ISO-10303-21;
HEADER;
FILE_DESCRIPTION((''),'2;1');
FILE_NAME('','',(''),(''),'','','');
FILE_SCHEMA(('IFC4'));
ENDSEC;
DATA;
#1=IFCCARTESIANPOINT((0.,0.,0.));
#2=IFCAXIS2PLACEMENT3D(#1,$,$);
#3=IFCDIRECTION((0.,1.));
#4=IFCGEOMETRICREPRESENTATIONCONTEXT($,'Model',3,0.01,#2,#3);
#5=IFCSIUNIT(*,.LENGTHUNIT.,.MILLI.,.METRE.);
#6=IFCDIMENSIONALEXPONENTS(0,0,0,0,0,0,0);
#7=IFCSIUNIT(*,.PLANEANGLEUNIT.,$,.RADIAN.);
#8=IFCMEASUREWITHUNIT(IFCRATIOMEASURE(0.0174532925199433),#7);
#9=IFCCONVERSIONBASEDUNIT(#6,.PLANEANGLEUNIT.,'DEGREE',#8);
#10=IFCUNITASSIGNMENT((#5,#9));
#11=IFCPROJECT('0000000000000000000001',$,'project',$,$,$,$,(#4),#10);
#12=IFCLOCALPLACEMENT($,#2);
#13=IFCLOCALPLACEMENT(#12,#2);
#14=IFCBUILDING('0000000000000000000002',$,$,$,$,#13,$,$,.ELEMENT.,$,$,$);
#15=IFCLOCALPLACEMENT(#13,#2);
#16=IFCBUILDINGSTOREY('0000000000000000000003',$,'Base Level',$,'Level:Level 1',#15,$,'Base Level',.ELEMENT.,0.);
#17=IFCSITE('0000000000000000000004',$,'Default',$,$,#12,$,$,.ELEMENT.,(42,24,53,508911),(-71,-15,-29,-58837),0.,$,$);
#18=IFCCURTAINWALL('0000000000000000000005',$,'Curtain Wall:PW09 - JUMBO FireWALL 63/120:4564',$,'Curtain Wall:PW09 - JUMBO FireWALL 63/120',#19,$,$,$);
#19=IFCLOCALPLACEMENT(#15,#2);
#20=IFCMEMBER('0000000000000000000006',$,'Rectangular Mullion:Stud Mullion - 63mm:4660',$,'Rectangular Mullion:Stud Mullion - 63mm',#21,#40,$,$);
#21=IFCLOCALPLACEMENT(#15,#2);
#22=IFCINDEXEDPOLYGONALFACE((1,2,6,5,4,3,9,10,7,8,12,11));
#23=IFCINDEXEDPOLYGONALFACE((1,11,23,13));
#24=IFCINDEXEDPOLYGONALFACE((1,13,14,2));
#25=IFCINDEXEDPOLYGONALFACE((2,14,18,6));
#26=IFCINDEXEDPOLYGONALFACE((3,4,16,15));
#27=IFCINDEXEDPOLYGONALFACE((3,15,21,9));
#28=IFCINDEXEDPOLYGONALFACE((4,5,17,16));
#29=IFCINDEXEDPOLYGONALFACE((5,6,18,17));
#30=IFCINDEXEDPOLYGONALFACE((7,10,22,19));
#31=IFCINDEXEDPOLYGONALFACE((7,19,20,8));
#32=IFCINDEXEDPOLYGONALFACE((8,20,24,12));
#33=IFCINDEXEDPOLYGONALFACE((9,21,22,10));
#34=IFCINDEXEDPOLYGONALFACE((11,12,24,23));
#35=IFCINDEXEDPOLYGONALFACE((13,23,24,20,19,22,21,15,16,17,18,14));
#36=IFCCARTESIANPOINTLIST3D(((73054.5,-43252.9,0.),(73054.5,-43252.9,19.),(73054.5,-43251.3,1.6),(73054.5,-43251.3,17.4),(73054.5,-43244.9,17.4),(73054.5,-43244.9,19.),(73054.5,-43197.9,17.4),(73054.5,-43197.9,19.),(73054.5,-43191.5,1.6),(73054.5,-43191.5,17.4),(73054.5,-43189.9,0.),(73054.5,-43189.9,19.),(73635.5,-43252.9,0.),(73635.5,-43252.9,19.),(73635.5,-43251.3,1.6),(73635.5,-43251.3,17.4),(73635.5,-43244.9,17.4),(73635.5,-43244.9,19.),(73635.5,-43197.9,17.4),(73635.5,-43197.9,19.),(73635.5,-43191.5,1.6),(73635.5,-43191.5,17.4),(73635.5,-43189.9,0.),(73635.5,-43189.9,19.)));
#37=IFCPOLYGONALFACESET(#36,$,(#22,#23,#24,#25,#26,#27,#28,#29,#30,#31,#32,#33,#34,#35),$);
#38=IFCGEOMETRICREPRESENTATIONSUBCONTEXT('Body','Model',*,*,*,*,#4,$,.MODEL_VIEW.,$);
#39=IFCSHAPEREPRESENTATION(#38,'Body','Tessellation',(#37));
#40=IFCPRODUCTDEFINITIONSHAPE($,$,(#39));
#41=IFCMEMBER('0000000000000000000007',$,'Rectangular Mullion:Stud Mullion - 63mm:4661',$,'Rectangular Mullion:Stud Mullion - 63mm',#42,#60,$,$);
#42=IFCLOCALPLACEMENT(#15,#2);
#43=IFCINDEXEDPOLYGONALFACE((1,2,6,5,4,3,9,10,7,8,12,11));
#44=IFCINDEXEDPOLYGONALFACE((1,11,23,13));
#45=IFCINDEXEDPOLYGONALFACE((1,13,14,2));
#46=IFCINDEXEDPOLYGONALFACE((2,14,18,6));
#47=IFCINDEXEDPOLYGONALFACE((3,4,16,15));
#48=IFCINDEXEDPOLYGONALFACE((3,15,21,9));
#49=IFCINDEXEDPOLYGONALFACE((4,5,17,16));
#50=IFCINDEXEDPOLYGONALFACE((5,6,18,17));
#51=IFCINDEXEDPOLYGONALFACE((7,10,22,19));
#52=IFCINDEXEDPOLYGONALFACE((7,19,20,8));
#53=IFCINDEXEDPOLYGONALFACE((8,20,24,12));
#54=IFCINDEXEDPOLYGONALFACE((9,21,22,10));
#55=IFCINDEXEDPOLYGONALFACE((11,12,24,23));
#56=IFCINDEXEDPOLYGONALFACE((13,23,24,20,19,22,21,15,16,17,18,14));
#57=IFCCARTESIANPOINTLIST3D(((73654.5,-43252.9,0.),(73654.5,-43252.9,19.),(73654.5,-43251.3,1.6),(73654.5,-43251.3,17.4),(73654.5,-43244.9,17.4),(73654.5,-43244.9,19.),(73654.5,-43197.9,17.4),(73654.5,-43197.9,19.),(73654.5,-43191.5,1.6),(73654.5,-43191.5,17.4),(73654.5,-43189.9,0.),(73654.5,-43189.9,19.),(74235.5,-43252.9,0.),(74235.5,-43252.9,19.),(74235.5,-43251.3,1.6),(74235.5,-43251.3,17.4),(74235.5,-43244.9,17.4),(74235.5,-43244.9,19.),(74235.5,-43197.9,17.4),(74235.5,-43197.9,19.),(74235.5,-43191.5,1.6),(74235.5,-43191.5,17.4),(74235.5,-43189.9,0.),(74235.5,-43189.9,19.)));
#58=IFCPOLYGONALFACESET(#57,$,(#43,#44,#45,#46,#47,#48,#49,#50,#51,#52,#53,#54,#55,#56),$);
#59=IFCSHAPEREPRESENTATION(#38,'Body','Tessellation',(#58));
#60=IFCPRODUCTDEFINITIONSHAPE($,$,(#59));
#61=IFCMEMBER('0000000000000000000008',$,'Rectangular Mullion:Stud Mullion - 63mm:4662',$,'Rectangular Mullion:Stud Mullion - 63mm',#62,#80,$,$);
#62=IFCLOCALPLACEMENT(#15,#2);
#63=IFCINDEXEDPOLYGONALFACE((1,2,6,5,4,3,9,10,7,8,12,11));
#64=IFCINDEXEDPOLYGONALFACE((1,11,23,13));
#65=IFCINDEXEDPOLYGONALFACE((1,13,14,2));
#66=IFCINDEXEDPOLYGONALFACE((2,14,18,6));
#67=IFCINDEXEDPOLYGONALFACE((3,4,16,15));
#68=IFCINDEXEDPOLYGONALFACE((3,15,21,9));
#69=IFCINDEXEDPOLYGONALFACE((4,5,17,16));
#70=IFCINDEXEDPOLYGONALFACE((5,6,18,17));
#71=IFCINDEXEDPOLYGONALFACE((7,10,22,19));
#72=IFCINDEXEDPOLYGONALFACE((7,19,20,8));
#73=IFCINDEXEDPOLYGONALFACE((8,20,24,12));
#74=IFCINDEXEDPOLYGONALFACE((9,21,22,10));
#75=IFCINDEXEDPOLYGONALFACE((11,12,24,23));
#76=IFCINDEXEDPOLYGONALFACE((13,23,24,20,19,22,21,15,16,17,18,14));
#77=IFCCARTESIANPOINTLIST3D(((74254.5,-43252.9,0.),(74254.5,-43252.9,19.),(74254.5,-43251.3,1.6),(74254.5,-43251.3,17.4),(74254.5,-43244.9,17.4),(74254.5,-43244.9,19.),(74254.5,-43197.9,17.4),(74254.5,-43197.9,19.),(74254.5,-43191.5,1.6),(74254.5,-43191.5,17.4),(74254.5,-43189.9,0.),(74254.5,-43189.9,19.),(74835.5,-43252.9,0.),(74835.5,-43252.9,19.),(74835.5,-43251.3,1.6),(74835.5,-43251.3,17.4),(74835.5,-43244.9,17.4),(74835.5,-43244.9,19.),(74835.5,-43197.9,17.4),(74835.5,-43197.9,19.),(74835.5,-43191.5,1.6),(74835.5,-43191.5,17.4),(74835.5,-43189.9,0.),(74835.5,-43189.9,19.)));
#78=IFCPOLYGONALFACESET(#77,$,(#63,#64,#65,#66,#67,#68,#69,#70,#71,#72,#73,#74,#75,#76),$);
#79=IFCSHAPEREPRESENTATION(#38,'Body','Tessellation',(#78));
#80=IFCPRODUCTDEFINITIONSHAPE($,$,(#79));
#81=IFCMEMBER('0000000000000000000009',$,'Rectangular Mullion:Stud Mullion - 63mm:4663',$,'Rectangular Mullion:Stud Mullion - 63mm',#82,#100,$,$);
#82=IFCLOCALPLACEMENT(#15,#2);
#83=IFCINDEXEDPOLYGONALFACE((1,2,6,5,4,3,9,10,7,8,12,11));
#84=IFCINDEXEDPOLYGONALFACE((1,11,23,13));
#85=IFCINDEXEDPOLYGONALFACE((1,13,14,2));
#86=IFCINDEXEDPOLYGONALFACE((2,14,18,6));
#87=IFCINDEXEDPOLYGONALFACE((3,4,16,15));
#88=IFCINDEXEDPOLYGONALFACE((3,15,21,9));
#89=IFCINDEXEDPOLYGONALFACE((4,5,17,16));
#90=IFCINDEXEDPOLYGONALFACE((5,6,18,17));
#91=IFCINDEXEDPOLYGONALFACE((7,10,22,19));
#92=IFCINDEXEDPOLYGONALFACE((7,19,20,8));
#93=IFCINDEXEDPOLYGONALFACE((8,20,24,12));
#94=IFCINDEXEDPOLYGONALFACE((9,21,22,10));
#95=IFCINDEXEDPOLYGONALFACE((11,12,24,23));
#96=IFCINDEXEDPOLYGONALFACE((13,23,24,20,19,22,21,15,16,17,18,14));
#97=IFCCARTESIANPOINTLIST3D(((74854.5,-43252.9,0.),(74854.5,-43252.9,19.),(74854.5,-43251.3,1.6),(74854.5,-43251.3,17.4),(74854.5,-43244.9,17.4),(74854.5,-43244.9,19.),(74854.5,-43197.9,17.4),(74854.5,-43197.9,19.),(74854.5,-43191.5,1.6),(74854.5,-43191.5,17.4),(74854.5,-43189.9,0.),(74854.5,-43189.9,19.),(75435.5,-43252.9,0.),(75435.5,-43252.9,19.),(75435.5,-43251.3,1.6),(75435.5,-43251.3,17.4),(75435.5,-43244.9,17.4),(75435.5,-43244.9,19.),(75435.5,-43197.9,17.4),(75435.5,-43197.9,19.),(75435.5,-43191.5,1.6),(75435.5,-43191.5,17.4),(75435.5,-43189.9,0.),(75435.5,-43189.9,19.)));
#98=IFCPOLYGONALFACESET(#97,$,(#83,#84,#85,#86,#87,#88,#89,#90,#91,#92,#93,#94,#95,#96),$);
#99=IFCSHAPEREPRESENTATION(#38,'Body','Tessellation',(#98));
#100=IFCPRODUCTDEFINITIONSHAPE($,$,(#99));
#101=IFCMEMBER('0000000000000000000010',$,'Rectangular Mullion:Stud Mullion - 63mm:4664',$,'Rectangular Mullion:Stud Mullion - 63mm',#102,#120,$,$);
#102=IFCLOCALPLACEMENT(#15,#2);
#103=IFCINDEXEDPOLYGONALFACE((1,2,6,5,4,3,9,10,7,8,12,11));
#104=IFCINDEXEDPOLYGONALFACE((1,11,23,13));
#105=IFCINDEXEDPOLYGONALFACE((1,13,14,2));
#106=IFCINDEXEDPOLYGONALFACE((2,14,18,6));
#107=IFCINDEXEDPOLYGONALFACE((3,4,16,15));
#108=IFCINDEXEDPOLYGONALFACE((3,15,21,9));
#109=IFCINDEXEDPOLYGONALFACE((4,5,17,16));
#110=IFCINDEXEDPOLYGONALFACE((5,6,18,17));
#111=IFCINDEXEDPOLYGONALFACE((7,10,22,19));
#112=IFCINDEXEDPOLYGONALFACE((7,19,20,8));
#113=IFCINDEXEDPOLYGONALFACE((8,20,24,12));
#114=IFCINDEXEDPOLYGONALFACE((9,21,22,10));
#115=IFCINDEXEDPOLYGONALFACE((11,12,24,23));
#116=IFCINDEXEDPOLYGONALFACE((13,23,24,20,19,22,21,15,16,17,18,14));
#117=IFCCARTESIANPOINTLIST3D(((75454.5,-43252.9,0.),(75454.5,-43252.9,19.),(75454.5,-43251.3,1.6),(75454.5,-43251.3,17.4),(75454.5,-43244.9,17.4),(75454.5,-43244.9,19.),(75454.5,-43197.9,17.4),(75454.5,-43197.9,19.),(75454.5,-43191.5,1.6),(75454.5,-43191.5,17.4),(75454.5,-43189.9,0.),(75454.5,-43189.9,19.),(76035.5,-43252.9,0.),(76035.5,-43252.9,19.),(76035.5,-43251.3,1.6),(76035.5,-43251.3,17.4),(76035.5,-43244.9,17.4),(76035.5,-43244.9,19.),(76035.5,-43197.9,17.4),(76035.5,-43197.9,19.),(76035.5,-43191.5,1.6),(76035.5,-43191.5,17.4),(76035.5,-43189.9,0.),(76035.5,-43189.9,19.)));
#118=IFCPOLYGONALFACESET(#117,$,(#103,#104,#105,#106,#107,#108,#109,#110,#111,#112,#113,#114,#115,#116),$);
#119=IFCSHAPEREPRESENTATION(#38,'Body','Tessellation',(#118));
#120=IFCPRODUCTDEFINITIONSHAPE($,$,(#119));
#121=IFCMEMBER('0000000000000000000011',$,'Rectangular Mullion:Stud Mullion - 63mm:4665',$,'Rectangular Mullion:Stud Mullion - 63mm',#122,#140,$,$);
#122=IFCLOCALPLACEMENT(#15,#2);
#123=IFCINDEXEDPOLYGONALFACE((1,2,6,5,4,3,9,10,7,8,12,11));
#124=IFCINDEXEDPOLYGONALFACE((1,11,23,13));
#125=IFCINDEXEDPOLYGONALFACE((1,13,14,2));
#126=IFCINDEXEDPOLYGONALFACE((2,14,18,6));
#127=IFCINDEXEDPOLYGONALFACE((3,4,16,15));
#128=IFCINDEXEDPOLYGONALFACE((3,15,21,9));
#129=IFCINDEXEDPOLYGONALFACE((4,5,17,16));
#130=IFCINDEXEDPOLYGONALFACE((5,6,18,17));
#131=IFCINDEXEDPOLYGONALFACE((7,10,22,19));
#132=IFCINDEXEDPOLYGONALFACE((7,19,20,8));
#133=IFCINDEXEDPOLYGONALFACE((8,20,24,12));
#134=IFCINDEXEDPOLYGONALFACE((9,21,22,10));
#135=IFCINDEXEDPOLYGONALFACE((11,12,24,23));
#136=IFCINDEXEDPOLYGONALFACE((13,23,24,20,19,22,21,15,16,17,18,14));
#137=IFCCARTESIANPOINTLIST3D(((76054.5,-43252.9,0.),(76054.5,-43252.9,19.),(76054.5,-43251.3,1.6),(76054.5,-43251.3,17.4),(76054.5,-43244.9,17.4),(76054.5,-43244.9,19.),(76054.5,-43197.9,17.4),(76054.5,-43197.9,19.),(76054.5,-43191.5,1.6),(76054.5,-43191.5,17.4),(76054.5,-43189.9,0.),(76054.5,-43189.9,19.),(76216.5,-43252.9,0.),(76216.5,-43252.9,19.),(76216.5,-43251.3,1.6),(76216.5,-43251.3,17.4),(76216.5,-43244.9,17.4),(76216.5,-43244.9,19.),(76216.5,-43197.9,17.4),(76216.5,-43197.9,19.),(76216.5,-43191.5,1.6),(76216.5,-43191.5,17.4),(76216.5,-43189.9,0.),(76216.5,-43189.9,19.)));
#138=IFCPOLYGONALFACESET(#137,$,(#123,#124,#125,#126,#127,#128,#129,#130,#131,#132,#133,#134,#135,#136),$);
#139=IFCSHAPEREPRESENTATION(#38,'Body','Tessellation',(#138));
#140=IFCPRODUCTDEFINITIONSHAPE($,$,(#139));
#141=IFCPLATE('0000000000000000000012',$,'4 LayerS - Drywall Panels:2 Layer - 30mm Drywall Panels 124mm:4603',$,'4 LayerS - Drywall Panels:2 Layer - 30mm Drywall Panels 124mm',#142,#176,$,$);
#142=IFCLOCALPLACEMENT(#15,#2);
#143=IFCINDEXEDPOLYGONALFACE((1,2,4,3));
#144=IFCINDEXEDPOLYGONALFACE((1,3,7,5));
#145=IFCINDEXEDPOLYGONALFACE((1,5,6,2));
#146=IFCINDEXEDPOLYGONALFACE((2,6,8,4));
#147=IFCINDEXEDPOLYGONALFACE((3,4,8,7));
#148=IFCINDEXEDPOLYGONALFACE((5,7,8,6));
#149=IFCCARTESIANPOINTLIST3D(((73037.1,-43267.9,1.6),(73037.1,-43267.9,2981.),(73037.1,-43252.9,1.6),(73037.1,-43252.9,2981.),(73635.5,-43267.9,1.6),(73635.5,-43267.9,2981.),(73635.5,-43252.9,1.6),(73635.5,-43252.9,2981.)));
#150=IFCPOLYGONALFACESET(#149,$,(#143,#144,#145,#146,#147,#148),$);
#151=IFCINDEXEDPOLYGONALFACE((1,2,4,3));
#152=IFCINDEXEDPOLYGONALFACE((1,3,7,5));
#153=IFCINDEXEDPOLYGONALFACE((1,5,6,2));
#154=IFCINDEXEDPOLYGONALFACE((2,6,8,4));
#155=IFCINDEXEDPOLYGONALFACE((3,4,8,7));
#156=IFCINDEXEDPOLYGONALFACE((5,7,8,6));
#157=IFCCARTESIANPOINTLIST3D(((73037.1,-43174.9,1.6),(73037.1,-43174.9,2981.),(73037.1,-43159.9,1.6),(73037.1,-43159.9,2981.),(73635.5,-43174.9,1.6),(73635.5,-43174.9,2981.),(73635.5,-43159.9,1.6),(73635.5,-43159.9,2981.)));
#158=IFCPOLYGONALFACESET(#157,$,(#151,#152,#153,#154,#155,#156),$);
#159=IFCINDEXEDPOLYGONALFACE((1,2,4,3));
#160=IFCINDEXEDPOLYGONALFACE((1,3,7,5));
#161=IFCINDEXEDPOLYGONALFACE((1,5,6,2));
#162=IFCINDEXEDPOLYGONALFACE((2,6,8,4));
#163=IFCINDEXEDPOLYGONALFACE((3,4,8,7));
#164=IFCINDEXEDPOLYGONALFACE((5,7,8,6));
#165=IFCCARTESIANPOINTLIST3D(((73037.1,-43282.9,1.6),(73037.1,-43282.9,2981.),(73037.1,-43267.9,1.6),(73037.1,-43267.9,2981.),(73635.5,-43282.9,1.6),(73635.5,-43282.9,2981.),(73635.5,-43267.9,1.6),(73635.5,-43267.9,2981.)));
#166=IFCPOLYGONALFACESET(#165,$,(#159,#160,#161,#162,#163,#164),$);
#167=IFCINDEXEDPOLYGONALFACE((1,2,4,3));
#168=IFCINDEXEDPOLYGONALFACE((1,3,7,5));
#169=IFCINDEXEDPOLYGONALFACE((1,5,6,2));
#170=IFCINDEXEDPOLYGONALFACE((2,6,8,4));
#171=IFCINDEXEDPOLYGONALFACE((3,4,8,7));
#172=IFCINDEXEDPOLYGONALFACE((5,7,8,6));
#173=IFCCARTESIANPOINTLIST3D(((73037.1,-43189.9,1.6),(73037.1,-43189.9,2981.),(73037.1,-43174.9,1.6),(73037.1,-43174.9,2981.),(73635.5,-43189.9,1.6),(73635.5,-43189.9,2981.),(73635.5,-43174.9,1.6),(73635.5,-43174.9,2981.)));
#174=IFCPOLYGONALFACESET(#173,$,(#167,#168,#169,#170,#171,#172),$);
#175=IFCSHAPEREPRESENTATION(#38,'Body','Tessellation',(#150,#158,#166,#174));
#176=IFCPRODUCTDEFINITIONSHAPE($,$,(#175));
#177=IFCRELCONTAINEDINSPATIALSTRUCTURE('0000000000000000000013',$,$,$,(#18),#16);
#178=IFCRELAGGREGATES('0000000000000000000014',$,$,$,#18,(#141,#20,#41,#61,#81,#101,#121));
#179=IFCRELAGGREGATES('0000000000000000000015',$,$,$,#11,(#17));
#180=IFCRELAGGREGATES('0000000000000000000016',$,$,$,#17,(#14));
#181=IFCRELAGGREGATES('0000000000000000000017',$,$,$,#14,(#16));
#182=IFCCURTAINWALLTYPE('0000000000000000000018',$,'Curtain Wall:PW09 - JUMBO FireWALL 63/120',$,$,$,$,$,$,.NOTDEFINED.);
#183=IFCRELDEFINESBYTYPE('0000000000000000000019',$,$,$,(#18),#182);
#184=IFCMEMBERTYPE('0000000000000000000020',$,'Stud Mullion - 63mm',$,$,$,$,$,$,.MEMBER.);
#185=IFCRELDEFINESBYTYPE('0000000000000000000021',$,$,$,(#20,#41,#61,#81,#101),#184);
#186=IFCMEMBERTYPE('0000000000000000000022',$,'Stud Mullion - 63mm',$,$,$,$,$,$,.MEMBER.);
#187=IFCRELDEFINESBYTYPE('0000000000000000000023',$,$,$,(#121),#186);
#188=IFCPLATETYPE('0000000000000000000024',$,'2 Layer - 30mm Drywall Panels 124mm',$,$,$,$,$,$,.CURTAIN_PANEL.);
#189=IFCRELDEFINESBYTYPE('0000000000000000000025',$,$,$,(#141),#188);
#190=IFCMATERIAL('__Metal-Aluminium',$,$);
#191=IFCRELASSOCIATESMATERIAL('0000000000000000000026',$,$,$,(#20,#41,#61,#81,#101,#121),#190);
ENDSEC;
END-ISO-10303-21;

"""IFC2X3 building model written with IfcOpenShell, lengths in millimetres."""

from ifc_helpers import new_model, entity, si_unit, converted_unit, direction, frame, frame_2d, origin, origin_2d_with_axis, place, context, subcontext, project, spatial, polyline, rectangle, outline, extrude, source, transform, mapped, material, type_object, type_shapes, element, aggregate, save


model = new_model("IFC2X3")

# Units and contexts
model_context = context("Model", 3, precision=0.01, world=origin(), true_north=direction((0.0, 1.0)))
body_context = subcontext(model_context, "Body", "Model", "MODEL_VIEW")
ifc_project = project(units=[si_unit("LENGTHUNIT", "METRE", prefix="MILLI"), converted_unit("PLANEANGLEUNIT", "DEGREE", entity("IfcRatioMeasure", 0.0174532925199433), si_unit("PLANEANGLEUNIT", "RADIAN"), dimensions=[0, 0, 0, 0, 0, 0, 0])], contexts=[model_context])

# Site, building, storey
site_placement = place(None, origin())
site = spatial("IfcSite", under=ifc_project, at=site_placement, Name="Default", CompositionType="ELEMENT", RefLatitude=(42, 24, 53, 508911), RefLongitude=(-71, -15, -29, -58837), RefElevation=0.0)
building_placement = place(site_placement, origin())
building = spatial("IfcBuilding", under=site, at=building_placement, CompositionType="ELEMENT")
storey_placement = place(building_placement, origin())
storey = spatial("IfcBuildingStorey", under=building, at=storey_placement, Name="Base Level", ObjectType="Level:Level 1", LongName="Base Level", CompositionType="ELEMENT", Elevation=0.0)

# Curtain wall, members, plate
curtain_wall_type = type_object("IfcCurtainWallType", Name="Curtain Wall:PW09 - JUMBO FireWALL 63/120", PredefinedType="NOTDEFINED")
curtain_wall_placement = place(building_placement, origin())
curtain_wall = element("IfcCurtainWall", 1, at=curtain_wall_placement, inside=storey, type_object=curtain_wall_type, Name="Curtain Wall:PW09 - JUMBO FireWALL 63/120:4564", ObjectType="Curtain Wall:PW09 - JUMBO FireWALL 63/120")
ifc_material = material(Name="__Metal-Aluminium")
member_type_1 = type_object("IfcMemberType", Name="Stud Mullion - 63mm", PredefinedType="MEMBER")
shared_shape_1 = source(origin(), body_context, "Body", "SweptSolid", [
    extrude(outline(polyline([(23.5, -6.6), (31.5, -6.6), (31.5, 12.4), (-31.5, 12.4), (-31.5, -6.6), (-23.5, -6.6), (-23.5, -5.0), (-29.9, -5.0), (-29.9, 10.8), (29.9, 10.8), (29.9, -5.0), (23.5, -5.0), (23.5, -6.6)])), frame((-12.4, 0.0, -581.0), z_axis=(0.0, 0.0, 1.0), x_axis=(0.0, -1.0, 0.0)), (0.0, 0.0, 1.0), 581.0),
])
type_shapes(member_type_1, [shared_shape_1])
member_1_placement = place(building_placement, frame((73054.5, -43221.4, 0.0), z_axis=(-1.0, 0.0, 0.0), x_axis=(0.0, 0.0, -1.0)))
member_1 = element("IfcMember", 2, at=member_1_placement, type_object=member_type_1, material=ifc_material, Name="Rectangular Mullion:Stud Mullion - 63mm:4660", ObjectType="Rectangular Mullion:Stud Mullion - 63mm", context=body_context, shape_type="MappedRepresentation", body=[
    mapped(shared_shape_1, transform((0.0, 0.0, 0.0), scale=1.0)),
])
member_2_placement = place(building_placement, frame((73654.5, -43221.4, 0.0), z_axis=(-1.0, 0.0, 0.0), x_axis=(0.0, 0.0, -1.0)))
member_2 = element("IfcMember", 3, at=member_2_placement, type_object=member_type_1, material=ifc_material, Name="Rectangular Mullion:Stud Mullion - 63mm:4661", ObjectType="Rectangular Mullion:Stud Mullion - 63mm", context=body_context, shape_type="MappedRepresentation", body=[
    mapped(shared_shape_1, transform((0.0, 0.0, 0.0), scale=1.0)),
])
member_3_placement = place(building_placement, frame((74254.5, -43221.4, 0.0), z_axis=(-1.0, 0.0, 0.0), x_axis=(0.0, 0.0, -1.0)))
member_3 = element("IfcMember", 4, at=member_3_placement, type_object=member_type_1, material=ifc_material, Name="Rectangular Mullion:Stud Mullion - 63mm:4662", ObjectType="Rectangular Mullion:Stud Mullion - 63mm", context=body_context, shape_type="MappedRepresentation", body=[
    mapped(shared_shape_1, transform((0.0, 0.0, 0.0), scale=1.0)),
])
member_4_placement = place(building_placement, frame((74854.5, -43221.4, 0.0), z_axis=(-1.0, 0.0, 0.0), x_axis=(0.0, 0.0, -1.0)))
member_4 = element("IfcMember", 5, at=member_4_placement, type_object=member_type_1, material=ifc_material, Name="Rectangular Mullion:Stud Mullion - 63mm:4663", ObjectType="Rectangular Mullion:Stud Mullion - 63mm", context=body_context, shape_type="MappedRepresentation", body=[
    mapped(shared_shape_1, transform((0.0, 0.0, 0.0), scale=1.0)),
])
member_5_placement = place(building_placement, frame((75454.5, -43221.4, 0.0), z_axis=(-1.0, 0.0, 0.0), x_axis=(0.0, 0.0, -1.0)))
member_5 = element("IfcMember", 6, at=member_5_placement, type_object=member_type_1, material=ifc_material, Name="Rectangular Mullion:Stud Mullion - 63mm:4664", ObjectType="Rectangular Mullion:Stud Mullion - 63mm", context=body_context, shape_type="MappedRepresentation", body=[
    mapped(shared_shape_1, transform((0.0, 0.0, 0.0), scale=1.0)),
])
member_type_2 = type_object("IfcMemberType", Name="Stud Mullion - 63mm", PredefinedType="MEMBER")
shared_shape_2 = source(origin(), body_context, "Body", "SweptSolid", [
    extrude(outline(polyline([(23.5, -6.6), (31.5, -6.6), (31.5, 12.4), (-31.5, 12.4), (-31.5, -6.6), (-23.5, -6.6), (-23.5, -5.0), (-29.9, -5.0), (-29.9, 10.8), (29.9, 10.8), (29.9, -5.0), (23.5, -5.0), (23.5, -6.6)])), frame((-12.4, 0.0, -162.0), z_axis=(0.0, 0.0, 1.0), x_axis=(0.0, -1.0, 0.0)), (0.0, 0.0, 1.0), 162.0),
])
type_shapes(member_type_2, [shared_shape_2])
member_6_placement = place(building_placement, frame((76054.5, -43221.4, 0.0), z_axis=(-1.0, 0.0, 0.0), x_axis=(0.0, 0.0, -1.0)))
member_6 = element("IfcMember", 7, at=member_6_placement, type_object=member_type_2, material=ifc_material, Name="Rectangular Mullion:Stud Mullion - 63mm:4665", ObjectType="Rectangular Mullion:Stud Mullion - 63mm", context=body_context, shape_type="MappedRepresentation", body=[
    mapped(shared_shape_2, transform((0.0, 0.0, 0.0), scale=1.0)),
])
plate_type_1 = type_object("IfcPlateType", Name="2 Layer - 30mm Drywall Panels 124mm", PredefinedType="CURTAIN_PANEL")
shared_shape_3 = source(origin(), body_context, "Body", "SweptSolid", [
    extrude(rectangle(XDim=15.0, YDim=598.4, at=origin_2d_with_axis()), frame((0.0, -39.0, 0.0), z_axis=(0.0, 0.0, 1.0), x_axis=(0.0, 1.0, 0.0)), (0.0, 0.0, 1.0), 2979.4),
    extrude(rectangle(XDim=15.0, YDim=598.4, at=origin_2d_with_axis()), frame((0.0, 54.0, 0.0), z_axis=(0.0, 0.0, 1.0), x_axis=(0.0, 1.0, 0.0)), (0.0, 0.0, 1.0), 2979.4),
    extrude(rectangle(XDim=598.4, YDim=15.0, at=frame_2d((0.0, 0.0), x_axis=(1.0, 0.0))), frame((0.0, -54.0, 0.0), z_axis=(0.0, 0.0, 1.0), x_axis=(-1.0, 0.0, 0.0)), (0.0, 0.0, 1.0), 2979.4),
    extrude(rectangle(XDim=15.0, YDim=598.4, at=frame_2d((0.0, 0.0), x_axis=(1.0, 0.0))), frame((0.0, 39.0, 0.0), z_axis=(0.0, 0.0, 1.0), x_axis=(0.0, 1.0, 0.0)), (0.0, 0.0, 1.0), 2979.4),
])
type_shapes(plate_type_1, [shared_shape_3])
plate_1_placement = place(curtain_wall_placement, frame((73336.3, -43221.4, 1.6)))
plate_1 = element("IfcPlate", 8, at=plate_1_placement, type_object=plate_type_1, Name="4 LayerS - Drywall Panels:2 Layer - 30mm Drywall Panels 124mm:4603", ObjectType="4 LayerS - Drywall Panels:2 Layer - 30mm Drywall Panels 124mm", context=body_context, shape_type="MappedRepresentation", body=[
    mapped(shared_shape_3, transform((0.0, 0.0, 0.0), scale=1.0)),
])
aggregate(curtain_wall, [plate_1, member_1, member_2, member_3, member_4, member_5, member_6])

save(model, "model.ifc")
